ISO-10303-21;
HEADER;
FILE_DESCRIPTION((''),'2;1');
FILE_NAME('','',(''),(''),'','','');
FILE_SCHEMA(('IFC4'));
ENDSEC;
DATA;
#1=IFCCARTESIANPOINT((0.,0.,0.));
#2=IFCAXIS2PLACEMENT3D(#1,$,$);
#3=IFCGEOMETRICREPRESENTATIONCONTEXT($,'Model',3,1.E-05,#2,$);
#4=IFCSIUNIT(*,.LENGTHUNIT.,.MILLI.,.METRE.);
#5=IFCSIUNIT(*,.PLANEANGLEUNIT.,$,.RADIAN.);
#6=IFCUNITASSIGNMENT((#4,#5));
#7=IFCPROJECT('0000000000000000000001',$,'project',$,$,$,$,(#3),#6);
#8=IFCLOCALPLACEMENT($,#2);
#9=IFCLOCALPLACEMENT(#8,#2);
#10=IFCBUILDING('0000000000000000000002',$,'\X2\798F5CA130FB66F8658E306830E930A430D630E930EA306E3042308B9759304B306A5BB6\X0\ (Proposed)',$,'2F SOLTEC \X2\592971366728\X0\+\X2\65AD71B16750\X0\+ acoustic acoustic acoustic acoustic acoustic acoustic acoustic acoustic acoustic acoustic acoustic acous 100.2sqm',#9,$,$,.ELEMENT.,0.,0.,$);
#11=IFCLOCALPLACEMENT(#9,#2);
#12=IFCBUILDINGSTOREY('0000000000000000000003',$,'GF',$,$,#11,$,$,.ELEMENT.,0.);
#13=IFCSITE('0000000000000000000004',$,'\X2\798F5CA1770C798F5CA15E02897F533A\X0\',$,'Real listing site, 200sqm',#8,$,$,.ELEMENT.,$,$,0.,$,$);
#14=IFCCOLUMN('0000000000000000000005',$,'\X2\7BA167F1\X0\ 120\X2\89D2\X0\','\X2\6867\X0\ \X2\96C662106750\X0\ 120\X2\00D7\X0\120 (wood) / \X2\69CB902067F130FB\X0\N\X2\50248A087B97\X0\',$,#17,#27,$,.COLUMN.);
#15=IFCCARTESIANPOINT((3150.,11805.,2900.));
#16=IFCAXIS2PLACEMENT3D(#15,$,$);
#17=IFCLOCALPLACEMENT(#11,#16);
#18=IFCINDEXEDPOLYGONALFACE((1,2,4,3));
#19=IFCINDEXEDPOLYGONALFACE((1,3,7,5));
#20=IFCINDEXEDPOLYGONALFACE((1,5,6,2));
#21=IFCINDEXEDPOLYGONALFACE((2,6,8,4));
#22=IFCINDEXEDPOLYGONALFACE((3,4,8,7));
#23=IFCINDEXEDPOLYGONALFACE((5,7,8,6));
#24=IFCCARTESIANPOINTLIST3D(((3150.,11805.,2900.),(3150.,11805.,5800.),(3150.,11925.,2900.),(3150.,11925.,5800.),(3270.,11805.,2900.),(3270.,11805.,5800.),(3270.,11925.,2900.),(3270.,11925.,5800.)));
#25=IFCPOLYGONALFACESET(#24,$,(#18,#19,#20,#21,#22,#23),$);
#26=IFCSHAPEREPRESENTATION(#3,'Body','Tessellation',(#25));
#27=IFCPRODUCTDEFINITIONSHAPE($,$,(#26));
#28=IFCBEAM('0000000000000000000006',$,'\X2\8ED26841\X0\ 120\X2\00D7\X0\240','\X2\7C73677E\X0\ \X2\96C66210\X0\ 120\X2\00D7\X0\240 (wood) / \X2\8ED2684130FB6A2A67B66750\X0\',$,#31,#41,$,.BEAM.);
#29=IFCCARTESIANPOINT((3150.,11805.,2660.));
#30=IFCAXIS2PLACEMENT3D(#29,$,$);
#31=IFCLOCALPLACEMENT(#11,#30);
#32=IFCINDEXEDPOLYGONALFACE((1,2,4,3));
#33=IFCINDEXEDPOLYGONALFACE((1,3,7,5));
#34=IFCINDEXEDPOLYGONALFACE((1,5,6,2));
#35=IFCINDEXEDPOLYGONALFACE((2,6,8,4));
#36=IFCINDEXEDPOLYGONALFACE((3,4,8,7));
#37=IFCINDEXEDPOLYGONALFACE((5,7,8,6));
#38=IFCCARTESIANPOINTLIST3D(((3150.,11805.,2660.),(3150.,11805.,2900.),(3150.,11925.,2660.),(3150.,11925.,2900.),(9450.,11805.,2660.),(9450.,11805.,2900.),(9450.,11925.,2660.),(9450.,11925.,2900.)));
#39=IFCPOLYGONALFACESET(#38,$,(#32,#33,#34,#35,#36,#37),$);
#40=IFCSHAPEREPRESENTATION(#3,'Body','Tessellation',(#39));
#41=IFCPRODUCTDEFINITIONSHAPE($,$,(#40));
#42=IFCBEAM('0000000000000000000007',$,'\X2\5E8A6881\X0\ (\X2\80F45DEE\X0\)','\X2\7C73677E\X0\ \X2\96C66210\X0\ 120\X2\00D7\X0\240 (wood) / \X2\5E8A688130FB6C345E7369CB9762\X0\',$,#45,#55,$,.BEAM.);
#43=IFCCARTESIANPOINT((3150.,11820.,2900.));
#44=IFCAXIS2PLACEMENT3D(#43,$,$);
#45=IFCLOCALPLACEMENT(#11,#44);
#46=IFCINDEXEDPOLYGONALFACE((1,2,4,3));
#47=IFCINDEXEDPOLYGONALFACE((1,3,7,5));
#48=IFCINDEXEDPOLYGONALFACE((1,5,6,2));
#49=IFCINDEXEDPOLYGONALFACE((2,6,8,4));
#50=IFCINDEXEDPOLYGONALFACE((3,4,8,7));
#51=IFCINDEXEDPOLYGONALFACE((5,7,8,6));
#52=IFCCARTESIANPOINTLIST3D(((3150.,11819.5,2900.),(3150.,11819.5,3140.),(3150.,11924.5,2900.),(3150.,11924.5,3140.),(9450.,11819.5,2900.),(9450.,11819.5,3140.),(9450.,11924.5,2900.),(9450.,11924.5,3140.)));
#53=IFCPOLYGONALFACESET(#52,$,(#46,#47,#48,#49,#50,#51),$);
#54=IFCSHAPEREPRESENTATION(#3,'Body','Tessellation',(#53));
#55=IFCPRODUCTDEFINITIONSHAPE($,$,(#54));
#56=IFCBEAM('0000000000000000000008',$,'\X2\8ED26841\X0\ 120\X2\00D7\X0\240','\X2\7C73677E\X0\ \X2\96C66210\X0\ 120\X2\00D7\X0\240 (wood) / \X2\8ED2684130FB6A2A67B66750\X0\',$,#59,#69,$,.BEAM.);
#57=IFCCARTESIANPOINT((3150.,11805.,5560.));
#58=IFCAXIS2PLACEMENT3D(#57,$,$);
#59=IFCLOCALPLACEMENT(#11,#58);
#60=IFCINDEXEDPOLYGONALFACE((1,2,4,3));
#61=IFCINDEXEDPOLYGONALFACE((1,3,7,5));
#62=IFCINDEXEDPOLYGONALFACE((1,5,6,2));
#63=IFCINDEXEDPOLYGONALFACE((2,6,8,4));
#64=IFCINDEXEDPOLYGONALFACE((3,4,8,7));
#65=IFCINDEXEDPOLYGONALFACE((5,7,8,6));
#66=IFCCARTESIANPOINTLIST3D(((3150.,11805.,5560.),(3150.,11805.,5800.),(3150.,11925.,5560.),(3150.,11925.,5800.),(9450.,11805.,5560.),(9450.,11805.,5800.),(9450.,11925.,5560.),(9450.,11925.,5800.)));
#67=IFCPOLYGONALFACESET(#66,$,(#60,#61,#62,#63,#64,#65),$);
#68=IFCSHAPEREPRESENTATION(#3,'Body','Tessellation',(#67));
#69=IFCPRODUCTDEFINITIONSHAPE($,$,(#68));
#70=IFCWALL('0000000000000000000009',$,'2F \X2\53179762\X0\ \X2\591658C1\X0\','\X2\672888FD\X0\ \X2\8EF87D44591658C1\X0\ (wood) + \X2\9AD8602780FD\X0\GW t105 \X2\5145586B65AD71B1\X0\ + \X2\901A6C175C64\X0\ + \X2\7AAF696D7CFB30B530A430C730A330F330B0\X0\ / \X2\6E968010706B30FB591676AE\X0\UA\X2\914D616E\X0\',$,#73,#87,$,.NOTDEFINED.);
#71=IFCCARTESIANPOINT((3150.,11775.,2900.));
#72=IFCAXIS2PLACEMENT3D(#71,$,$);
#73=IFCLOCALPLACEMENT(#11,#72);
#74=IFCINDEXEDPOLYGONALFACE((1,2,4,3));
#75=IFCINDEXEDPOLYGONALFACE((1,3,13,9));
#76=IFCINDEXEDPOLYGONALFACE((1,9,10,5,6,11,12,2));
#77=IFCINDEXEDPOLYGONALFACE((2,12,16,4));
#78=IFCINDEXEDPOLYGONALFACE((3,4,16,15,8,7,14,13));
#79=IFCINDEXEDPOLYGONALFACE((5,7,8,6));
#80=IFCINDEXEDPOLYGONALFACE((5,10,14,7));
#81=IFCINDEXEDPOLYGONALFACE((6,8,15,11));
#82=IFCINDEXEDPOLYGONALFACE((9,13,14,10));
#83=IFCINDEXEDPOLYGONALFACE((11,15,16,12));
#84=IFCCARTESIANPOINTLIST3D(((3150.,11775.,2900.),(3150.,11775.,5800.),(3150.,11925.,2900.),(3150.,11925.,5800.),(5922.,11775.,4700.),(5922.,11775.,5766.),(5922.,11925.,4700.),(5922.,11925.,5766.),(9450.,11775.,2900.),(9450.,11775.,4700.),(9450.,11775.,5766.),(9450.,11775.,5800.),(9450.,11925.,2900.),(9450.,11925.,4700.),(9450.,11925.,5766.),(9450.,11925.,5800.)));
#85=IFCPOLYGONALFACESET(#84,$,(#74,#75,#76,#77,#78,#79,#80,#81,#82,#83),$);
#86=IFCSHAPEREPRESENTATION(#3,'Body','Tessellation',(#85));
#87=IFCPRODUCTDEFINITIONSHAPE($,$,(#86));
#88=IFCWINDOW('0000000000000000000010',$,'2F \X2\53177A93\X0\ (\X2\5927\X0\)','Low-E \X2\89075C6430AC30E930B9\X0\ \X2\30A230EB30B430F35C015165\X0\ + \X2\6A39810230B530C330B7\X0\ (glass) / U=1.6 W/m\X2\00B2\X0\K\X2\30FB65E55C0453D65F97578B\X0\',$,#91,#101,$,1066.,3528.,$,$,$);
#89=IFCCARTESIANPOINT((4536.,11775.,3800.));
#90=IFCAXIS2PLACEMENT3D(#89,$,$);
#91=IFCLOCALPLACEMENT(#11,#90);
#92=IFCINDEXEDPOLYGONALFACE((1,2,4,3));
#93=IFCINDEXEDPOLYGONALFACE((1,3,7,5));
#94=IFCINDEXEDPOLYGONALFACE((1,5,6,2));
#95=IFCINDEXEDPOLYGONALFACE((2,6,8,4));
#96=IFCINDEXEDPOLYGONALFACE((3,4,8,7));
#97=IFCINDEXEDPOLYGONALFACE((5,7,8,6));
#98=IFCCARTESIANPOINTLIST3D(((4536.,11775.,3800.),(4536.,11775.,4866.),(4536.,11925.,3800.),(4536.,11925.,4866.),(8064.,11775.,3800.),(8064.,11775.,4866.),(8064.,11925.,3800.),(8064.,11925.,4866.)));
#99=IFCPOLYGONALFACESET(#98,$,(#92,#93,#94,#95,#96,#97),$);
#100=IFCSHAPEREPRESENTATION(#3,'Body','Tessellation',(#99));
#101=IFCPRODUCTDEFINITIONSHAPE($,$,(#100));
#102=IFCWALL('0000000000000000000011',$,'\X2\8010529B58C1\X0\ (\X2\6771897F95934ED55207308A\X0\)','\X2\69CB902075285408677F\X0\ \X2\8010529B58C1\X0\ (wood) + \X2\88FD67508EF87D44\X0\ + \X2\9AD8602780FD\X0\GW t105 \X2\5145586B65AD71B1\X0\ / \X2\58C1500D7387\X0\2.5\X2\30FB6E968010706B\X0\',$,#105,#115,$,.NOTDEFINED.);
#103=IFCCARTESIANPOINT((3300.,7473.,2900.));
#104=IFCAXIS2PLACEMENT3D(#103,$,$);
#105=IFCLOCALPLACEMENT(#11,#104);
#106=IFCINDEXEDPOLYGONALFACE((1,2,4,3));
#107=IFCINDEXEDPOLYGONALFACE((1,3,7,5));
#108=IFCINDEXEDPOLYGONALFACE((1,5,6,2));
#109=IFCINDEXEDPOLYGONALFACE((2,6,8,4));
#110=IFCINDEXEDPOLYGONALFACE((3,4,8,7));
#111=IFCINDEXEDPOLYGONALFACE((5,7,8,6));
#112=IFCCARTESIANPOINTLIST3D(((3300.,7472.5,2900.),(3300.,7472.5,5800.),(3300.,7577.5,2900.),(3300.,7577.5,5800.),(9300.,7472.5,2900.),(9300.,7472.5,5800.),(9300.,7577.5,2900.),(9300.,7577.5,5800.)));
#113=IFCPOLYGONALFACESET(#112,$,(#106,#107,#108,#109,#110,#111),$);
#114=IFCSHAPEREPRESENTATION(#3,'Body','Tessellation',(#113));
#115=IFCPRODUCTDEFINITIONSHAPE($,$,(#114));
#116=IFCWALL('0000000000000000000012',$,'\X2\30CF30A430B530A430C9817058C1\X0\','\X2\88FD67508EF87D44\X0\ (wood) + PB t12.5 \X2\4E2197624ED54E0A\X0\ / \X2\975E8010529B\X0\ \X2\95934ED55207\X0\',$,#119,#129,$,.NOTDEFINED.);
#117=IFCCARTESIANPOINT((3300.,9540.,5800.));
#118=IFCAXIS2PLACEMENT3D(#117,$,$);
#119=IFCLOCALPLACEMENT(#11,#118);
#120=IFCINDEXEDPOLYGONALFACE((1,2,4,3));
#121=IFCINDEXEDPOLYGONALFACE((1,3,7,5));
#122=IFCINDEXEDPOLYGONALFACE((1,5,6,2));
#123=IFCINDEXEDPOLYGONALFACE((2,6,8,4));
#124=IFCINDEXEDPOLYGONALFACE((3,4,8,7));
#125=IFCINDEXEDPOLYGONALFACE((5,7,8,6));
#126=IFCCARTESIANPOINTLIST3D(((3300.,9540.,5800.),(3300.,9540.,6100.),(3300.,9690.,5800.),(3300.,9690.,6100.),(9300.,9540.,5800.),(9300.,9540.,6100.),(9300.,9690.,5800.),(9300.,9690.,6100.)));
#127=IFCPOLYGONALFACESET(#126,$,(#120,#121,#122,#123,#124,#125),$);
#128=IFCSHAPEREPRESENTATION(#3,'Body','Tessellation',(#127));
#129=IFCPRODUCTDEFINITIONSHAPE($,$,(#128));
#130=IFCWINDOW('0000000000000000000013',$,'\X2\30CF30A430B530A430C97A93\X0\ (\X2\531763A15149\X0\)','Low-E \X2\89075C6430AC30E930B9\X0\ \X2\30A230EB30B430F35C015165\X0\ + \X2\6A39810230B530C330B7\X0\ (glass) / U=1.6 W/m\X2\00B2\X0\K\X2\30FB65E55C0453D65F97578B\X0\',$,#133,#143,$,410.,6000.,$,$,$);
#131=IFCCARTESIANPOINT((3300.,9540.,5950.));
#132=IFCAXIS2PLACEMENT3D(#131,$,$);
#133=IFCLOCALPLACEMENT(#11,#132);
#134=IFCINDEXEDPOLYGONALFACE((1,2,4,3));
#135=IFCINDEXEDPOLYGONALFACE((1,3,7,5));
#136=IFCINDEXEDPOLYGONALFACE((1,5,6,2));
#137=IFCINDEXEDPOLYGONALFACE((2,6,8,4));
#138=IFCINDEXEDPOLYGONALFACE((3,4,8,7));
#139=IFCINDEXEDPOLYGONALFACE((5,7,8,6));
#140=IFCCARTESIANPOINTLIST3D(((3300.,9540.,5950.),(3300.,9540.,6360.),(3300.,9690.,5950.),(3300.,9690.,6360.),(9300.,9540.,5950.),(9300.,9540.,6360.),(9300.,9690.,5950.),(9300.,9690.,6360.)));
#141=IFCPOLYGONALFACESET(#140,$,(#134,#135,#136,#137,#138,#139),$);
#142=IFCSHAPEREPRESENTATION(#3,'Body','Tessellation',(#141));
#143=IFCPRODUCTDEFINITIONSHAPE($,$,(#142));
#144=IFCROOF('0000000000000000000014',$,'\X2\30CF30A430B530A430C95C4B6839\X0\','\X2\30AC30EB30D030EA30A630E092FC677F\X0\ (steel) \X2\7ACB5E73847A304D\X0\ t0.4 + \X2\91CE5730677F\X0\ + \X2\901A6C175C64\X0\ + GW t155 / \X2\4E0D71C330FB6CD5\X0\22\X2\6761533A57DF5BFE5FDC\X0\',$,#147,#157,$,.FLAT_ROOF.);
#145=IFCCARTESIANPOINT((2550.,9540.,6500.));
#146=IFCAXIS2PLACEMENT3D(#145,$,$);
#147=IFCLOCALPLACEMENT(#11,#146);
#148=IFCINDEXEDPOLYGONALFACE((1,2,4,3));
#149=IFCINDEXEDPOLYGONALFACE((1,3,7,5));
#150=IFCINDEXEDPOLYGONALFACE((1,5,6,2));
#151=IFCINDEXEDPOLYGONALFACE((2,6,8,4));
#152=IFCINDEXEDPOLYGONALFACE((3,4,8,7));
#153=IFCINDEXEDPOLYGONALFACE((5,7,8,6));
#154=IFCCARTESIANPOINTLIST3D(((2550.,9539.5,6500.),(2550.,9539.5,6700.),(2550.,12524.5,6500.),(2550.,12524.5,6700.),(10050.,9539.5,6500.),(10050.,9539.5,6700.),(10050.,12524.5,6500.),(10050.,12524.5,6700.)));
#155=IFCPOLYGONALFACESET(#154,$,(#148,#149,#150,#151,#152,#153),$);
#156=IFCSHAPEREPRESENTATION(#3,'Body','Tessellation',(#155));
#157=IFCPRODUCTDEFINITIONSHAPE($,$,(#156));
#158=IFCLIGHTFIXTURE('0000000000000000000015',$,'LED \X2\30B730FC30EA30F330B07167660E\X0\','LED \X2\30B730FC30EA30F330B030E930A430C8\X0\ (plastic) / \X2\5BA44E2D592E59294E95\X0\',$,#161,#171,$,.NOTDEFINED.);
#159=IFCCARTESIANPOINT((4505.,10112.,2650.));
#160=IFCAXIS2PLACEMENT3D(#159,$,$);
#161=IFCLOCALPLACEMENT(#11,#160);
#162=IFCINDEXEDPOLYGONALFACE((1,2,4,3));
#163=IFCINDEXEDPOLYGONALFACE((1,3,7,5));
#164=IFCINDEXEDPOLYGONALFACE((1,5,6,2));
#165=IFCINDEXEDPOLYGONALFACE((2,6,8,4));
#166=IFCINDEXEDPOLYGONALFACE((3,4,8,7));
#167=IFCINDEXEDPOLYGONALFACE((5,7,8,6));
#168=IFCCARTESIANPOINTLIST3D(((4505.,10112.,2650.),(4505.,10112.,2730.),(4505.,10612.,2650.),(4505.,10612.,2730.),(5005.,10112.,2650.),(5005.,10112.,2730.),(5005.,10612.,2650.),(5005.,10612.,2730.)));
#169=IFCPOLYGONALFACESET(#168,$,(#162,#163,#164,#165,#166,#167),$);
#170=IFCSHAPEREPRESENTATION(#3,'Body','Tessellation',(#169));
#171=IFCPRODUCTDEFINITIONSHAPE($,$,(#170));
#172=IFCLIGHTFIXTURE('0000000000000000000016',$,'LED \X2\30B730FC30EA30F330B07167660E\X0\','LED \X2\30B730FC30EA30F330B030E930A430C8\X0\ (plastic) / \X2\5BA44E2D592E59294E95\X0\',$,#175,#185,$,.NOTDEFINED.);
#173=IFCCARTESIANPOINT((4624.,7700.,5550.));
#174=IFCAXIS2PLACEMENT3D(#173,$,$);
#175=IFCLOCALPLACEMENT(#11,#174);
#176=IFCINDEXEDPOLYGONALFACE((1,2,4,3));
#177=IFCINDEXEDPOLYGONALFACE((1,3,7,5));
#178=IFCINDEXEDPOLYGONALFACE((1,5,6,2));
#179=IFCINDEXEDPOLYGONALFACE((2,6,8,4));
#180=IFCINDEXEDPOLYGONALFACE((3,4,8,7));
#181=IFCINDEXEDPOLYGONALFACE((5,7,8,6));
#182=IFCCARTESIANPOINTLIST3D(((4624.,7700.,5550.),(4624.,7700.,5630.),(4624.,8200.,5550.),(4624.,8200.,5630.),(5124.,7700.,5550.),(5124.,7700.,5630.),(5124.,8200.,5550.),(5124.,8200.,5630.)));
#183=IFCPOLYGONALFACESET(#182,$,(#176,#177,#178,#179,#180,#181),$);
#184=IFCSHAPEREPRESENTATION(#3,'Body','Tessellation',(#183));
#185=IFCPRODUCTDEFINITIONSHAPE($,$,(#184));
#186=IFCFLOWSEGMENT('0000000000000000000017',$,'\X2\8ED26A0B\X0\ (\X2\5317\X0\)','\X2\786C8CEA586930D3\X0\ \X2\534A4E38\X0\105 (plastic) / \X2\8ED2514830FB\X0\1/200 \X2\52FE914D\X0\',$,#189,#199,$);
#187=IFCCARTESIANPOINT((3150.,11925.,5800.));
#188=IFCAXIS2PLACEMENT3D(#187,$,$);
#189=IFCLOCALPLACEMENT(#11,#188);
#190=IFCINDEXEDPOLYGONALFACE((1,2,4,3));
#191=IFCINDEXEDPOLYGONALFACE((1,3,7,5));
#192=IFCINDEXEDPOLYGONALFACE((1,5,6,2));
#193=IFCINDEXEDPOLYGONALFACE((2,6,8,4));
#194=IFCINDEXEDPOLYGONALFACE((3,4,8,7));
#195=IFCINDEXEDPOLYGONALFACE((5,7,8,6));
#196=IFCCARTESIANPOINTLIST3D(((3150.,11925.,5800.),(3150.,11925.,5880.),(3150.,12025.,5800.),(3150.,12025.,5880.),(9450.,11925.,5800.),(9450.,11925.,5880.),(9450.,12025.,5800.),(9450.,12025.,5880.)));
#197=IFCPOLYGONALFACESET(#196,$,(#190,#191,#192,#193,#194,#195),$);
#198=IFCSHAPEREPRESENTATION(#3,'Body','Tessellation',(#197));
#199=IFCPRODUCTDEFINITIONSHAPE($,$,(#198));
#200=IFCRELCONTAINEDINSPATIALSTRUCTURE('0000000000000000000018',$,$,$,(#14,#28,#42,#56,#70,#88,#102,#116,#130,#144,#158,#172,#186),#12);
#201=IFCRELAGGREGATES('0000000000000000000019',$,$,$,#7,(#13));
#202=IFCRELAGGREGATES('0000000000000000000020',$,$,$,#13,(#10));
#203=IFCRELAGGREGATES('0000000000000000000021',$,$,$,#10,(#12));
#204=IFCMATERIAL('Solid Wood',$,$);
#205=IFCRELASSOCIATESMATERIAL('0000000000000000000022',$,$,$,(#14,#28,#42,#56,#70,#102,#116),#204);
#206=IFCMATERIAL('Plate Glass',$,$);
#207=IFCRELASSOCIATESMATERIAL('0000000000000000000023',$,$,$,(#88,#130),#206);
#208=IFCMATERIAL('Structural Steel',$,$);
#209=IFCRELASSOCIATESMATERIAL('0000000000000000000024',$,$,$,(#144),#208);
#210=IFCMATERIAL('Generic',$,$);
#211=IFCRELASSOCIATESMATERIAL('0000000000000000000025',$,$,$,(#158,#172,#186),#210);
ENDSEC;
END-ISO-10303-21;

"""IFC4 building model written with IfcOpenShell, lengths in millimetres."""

from ifc_helpers import new_model, si_unit, frame, frame_2d, origin, place, context, project, spatial, rectangle, extrude, material, element, fill, save


model = new_model("IFC4")

# Units and contexts
model_context = context("Model", 3, precision=1e-05, world=origin())
ifc_project = project(units=[si_unit("LENGTHUNIT", "METRE", prefix="MILLI"), si_unit("PLANEANGLEUNIT", "RADIAN")], contexts=[model_context])

# Site, building, storey
site_placement = place(None, origin())
site = spatial("IfcSite", under=ifc_project, at=site_placement, Name="福岡県福岡市西区", ObjectType="Real listing site, 200sqm", CompositionType="ELEMENT", RefElevation=0.0)
building_placement = place(site_placement, origin())
building = spatial("IfcBuilding", under=site, at=building_placement, Name="福岡・書斎とライブラリのある静かな家 (Proposed)", ObjectType="2F SOLTEC 天然木+断熱材+ acoustic acoustic acoustic acoustic acoustic acoustic acoustic acoustic acoustic acoustic acoustic acous 100.2sqm", CompositionType="ELEMENT", ElevationOfRefHeight=0.0, ElevationOfTerrain=0.0)
storey_placement = place(building_placement, origin())
storey = spatial("IfcBuildingStorey", under=building, at=storey_placement, Name="GF", CompositionType="ELEMENT", Elevation=0.0)

# Column
ifc_material_1 = material(Name="Solid Wood")
column_1_placement = place(storey_placement, frame((3150.0, 11805.0, 2900.0)))
element("IfcColumn", 1, at=column_1_placement, inside=storey, material=ifc_material_1, Name="管柱 120角", Description="桧 集成材 120×120 (wood) / 構造柱・N値計算", PredefinedType="COLUMN", context=model_context, shape_type="SweptSolid", body=[
    extrude(rectangle(XDim=120.0, YDim=120.0, at=frame_2d((60.0, 60.0))), frame((3150.0, 11805.0, 2900.0)), (0.0, 0.0, 1.0), 2900.0),
])

# Beams
beam_1_placement = place(storey_placement, frame((3150.0, 11805.0, 2660.0)))
element("IfcBeam", 2, at=beam_1_placement, inside=storey, material=ifc_material_1, Name="軒桁 120×240", Description="米松 集成 120×240 (wood) / 軒桁・横架材", PredefinedType="BEAM", context=model_context, shape_type="SweptSolid", body=[
    extrude(rectangle(XDim=6300.0, YDim=120.0, at=frame_2d((3150.0, 60.0))), frame((3150.0, 11805.0, 2660.0)), (0.0, 0.0, 1.0), 240.0),
])
beam_2_placement = place(storey_placement, frame((3150.0, 11820.0, 2900.0)))
element("IfcBeam", 3, at=beam_2_placement, inside=storey, material=ifc_material_1, Name="床梁 (胴差)", Description="米松 集成 120×240 (wood) / 床梁・水平構面", PredefinedType="BEAM", context=model_context, shape_type="SweptSolid", body=[
    extrude(rectangle(XDim=6300.0, YDim=105.0, at=frame_2d((3150.0, 52.0))), frame((3150.0, 11820.0, 2900.0)), (0.0, 0.0, 1.0), 240.0),
])
beam_3_placement = place(storey_placement, frame((3150.0, 11805.0, 5560.0)))
element("IfcBeam", 4, at=beam_3_placement, inside=storey, material=ifc_material_1, Name="軒桁 120×240", Description="米松 集成 120×240 (wood) / 軒桁・横架材", PredefinedType="BEAM", context=model_context, shape_type="SweptSolid", body=[
    extrude(rectangle(XDim=6300.0, YDim=120.0, at=frame_2d((3150.0, 60.0))), frame((3150.0, 11805.0, 5560.0)), (0.0, 0.0, 1.0), 240.0),
])

# Wall, opening, window
wall_1_placement = place(storey_placement, frame((3150.0, 11775.0, 2900.0)))
wall_1 = element("IfcWall", 5, at=wall_1_placement, inside=storey, material=ifc_material_1, Name="2F 北面 外壁", Description="木製 軸組外壁 (wood) + 高性能GW t105 充填断熱 + 通気層 + 窯業系サイディング / 準耐火・外皮UA配慮", PredefinedType="NOTDEFINED", context=model_context, shape_type="SweptSolid", body=[
    extrude(rectangle(XDim=6300.0, YDim=150.0, at=frame_2d((3150.0, 75.0))), frame((3150.0, 11775.0, 2900.0)), (0.0, 0.0, 1.0), 2900.0),
])
opening_1_placement = place(storey_placement, frame((4536.0, 11775.0, 3800.0)))
opening_1 = element("IfcOpeningElement", 6, at=opening_1_placement, cuts=wall_1, PredefinedType="NOTDEFINED", context=model_context, shape_type="SweptSolid", body=[
    extrude(rectangle(XDim=3528.0, YDim=150.0, at=frame_2d((1764.0, 75.0))), frame((4536.0, 11775.0, 3800.0)), (0.0, 0.0, 1.0), 1066.0),
])
ifc_material_2 = material(Name="Plate Glass")
window_1_placement = place(storey_placement, frame((4536.0, 11775.0, 3800.0)))
window_1 = element("IfcWindow", 7, at=window_1_placement, inside=storey, material=ifc_material_2, Name="2F 北窓 (大)", Description="Low-E 複層ガラス アルゴン封入 + 樹脂サッシ (glass) / U=1.6 W/m²K・日射取得型", OverallHeight=1066.0, OverallWidth=3528.0, context=model_context, shape_type="SweptSolid", body=[
    extrude(rectangle(XDim=3528.0, YDim=150.0, at=frame_2d((1764.0, 75.0))), frame((4536.0, 11775.0, 3800.0)), (0.0, 0.0, 1.0), 1066.0),
])
fill(opening_1, window_1)

# Wall
wall_2_placement = place(storey_placement, frame((3300.0, 7473.0, 2900.0)))
element("IfcWall", 8, at=wall_2_placement, inside=storey, material=ifc_material_1, Name="耐力壁 (東西間仕切り)", Description="構造用合板 耐力壁 (wood) + 製材軸組 + 高性能GW t105 充填断熱 / 壁倍率2.5・準耐火", PredefinedType="NOTDEFINED", context=model_context, shape_type="SweptSolid", body=[
    extrude(rectangle(XDim=6000.0, YDim=105.0, at=frame_2d((3000.0, 52.0))), frame((3300.0, 7473.0, 2900.0)), (0.0, 0.0, 1.0), 2900.0),
])

# Wall, opening, window
wall_3_placement = place(storey_placement, frame((3300.0, 9540.0, 5800.0)))
wall_3 = element("IfcWall", 9, at=wall_3_placement, inside=storey, material=ifc_material_1, Name="ハイサイド腰壁", Description="製材軸組 (wood) + PB t12.5 両面仕上 / 非耐力 間仕切", PredefinedType="NOTDEFINED", context=model_context, shape_type="SweptSolid", body=[
    extrude(rectangle(XDim=6000.0, YDim=150.0, at=frame_2d((3000.0, 75.0))), frame((3300.0, 9540.0, 5800.0)), (0.0, 0.0, 1.0), 700.0),
])
opening_2_placement = place(storey_placement, frame((3300.0, 9540.0, 5950.0)))
opening_2 = element("IfcOpeningElement", 10, at=opening_2_placement, cuts=wall_3, PredefinedType="NOTDEFINED", context=model_context, shape_type="SweptSolid", body=[
    extrude(rectangle(XDim=6000.0, YDim=150.0, at=frame_2d((3000.0, 75.0))), frame((3300.0, 9540.0, 5950.0)), (0.0, 0.0, 1.0), 410.0),
])
window_2_placement = place(storey_placement, frame((3300.0, 9540.0, 5950.0)))
window_2 = element("IfcWindow", 11, at=window_2_placement, inside=storey, material=ifc_material_2, Name="ハイサイド窓 (北採光)", Description="Low-E 複層ガラス アルゴン封入 + 樹脂サッシ (glass) / U=1.6 W/m²K・日射取得型", OverallHeight=410.0, OverallWidth=6000.0, context=model_context, shape_type="SweptSolid", body=[
    extrude(rectangle(XDim=6000.0, YDim=150.0, at=frame_2d((3000.0, 75.0))), frame((3300.0, 9540.0, 5950.0)), (0.0, 0.0, 1.0), 410.0),
])
fill(opening_2, window_2)

# Roof
ifc_material_3 = material(Name="Structural Steel")
roof_placement = place(storey_placement, frame((2550.0, 9540.0, 6500.0)))
element("IfcRoof", 12, at=roof_placement, inside=storey, material=ifc_material_3, Name="ハイサイド屋根", Description="ガルバリウム鋼板 (steel) 立平葺き t0.4 + 野地板 + 通気層 + GW t155 / 不燃・法22条区域対応", PredefinedType="FLAT_ROOF", context=model_context, shape_type="SweptSolid", body=[
    extrude(rectangle(XDim=7500.0, YDim=2985.0, at=frame_2d((3750.0, 1492.0))), frame((2550.0, 9540.0, 6500.0)), (0.0, 0.0, 1.0), 200.0),
])

# Light fixtures
ifc_material_4 = material(Name="Generic")
light_fixture_1_placement = place(storey_placement, frame((4505.0, 10112.0, 2650.0)))
element("IfcLightFixture", 13, at=light_fixture_1_placement, inside=storey, material=ifc_material_4, Name="LED シーリング照明", Description="LED シーリングライト (plastic) / 室中央天井", PredefinedType="NOTDEFINED", context=model_context, shape_type="SweptSolid", body=[
    extrude(rectangle(XDim=500.0, YDim=500.0, at=frame_2d((250.0, 250.0))), frame((4505.0, 10112.0, 2650.0)), (0.0, 0.0, 1.0), 80.0),
])
light_fixture_2_placement = place(storey_placement, frame((4624.0, 7700.0, 5550.0)))
element("IfcLightFixture", 14, at=light_fixture_2_placement, inside=storey, material=ifc_material_4, Name="LED シーリング照明", Description="LED シーリングライト (plastic) / 室中央天井", PredefinedType="NOTDEFINED", context=model_context, shape_type="SweptSolid", body=[
    extrude(rectangle(XDim=500.0, YDim=500.0, at=frame_2d((250.0, 250.0))), frame((4624.0, 7700.0, 5550.0)), (0.0, 0.0, 1.0), 80.0),
])

# Flow segment
flow_segment_placement = place(storey_placement, frame((3150.0, 11925.0, 5800.0)))
element("IfcFlowSegment", 15, at=flow_segment_placement, inside=storey, material=ifc_material_4, Name="軒樋 (北)", Description="硬質塩ビ 半丸105 (plastic) / 軒先・1/200 勾配", context=model_context, shape_type="SweptSolid", body=[
    extrude(rectangle(XDim=6300.0, YDim=100.0, at=frame_2d((3150.0, 50.0))), frame((3150.0, 11925.0, 5800.0)), (0.0, 0.0, 1.0), 80.0),
])

save(model, "model.ifc")
